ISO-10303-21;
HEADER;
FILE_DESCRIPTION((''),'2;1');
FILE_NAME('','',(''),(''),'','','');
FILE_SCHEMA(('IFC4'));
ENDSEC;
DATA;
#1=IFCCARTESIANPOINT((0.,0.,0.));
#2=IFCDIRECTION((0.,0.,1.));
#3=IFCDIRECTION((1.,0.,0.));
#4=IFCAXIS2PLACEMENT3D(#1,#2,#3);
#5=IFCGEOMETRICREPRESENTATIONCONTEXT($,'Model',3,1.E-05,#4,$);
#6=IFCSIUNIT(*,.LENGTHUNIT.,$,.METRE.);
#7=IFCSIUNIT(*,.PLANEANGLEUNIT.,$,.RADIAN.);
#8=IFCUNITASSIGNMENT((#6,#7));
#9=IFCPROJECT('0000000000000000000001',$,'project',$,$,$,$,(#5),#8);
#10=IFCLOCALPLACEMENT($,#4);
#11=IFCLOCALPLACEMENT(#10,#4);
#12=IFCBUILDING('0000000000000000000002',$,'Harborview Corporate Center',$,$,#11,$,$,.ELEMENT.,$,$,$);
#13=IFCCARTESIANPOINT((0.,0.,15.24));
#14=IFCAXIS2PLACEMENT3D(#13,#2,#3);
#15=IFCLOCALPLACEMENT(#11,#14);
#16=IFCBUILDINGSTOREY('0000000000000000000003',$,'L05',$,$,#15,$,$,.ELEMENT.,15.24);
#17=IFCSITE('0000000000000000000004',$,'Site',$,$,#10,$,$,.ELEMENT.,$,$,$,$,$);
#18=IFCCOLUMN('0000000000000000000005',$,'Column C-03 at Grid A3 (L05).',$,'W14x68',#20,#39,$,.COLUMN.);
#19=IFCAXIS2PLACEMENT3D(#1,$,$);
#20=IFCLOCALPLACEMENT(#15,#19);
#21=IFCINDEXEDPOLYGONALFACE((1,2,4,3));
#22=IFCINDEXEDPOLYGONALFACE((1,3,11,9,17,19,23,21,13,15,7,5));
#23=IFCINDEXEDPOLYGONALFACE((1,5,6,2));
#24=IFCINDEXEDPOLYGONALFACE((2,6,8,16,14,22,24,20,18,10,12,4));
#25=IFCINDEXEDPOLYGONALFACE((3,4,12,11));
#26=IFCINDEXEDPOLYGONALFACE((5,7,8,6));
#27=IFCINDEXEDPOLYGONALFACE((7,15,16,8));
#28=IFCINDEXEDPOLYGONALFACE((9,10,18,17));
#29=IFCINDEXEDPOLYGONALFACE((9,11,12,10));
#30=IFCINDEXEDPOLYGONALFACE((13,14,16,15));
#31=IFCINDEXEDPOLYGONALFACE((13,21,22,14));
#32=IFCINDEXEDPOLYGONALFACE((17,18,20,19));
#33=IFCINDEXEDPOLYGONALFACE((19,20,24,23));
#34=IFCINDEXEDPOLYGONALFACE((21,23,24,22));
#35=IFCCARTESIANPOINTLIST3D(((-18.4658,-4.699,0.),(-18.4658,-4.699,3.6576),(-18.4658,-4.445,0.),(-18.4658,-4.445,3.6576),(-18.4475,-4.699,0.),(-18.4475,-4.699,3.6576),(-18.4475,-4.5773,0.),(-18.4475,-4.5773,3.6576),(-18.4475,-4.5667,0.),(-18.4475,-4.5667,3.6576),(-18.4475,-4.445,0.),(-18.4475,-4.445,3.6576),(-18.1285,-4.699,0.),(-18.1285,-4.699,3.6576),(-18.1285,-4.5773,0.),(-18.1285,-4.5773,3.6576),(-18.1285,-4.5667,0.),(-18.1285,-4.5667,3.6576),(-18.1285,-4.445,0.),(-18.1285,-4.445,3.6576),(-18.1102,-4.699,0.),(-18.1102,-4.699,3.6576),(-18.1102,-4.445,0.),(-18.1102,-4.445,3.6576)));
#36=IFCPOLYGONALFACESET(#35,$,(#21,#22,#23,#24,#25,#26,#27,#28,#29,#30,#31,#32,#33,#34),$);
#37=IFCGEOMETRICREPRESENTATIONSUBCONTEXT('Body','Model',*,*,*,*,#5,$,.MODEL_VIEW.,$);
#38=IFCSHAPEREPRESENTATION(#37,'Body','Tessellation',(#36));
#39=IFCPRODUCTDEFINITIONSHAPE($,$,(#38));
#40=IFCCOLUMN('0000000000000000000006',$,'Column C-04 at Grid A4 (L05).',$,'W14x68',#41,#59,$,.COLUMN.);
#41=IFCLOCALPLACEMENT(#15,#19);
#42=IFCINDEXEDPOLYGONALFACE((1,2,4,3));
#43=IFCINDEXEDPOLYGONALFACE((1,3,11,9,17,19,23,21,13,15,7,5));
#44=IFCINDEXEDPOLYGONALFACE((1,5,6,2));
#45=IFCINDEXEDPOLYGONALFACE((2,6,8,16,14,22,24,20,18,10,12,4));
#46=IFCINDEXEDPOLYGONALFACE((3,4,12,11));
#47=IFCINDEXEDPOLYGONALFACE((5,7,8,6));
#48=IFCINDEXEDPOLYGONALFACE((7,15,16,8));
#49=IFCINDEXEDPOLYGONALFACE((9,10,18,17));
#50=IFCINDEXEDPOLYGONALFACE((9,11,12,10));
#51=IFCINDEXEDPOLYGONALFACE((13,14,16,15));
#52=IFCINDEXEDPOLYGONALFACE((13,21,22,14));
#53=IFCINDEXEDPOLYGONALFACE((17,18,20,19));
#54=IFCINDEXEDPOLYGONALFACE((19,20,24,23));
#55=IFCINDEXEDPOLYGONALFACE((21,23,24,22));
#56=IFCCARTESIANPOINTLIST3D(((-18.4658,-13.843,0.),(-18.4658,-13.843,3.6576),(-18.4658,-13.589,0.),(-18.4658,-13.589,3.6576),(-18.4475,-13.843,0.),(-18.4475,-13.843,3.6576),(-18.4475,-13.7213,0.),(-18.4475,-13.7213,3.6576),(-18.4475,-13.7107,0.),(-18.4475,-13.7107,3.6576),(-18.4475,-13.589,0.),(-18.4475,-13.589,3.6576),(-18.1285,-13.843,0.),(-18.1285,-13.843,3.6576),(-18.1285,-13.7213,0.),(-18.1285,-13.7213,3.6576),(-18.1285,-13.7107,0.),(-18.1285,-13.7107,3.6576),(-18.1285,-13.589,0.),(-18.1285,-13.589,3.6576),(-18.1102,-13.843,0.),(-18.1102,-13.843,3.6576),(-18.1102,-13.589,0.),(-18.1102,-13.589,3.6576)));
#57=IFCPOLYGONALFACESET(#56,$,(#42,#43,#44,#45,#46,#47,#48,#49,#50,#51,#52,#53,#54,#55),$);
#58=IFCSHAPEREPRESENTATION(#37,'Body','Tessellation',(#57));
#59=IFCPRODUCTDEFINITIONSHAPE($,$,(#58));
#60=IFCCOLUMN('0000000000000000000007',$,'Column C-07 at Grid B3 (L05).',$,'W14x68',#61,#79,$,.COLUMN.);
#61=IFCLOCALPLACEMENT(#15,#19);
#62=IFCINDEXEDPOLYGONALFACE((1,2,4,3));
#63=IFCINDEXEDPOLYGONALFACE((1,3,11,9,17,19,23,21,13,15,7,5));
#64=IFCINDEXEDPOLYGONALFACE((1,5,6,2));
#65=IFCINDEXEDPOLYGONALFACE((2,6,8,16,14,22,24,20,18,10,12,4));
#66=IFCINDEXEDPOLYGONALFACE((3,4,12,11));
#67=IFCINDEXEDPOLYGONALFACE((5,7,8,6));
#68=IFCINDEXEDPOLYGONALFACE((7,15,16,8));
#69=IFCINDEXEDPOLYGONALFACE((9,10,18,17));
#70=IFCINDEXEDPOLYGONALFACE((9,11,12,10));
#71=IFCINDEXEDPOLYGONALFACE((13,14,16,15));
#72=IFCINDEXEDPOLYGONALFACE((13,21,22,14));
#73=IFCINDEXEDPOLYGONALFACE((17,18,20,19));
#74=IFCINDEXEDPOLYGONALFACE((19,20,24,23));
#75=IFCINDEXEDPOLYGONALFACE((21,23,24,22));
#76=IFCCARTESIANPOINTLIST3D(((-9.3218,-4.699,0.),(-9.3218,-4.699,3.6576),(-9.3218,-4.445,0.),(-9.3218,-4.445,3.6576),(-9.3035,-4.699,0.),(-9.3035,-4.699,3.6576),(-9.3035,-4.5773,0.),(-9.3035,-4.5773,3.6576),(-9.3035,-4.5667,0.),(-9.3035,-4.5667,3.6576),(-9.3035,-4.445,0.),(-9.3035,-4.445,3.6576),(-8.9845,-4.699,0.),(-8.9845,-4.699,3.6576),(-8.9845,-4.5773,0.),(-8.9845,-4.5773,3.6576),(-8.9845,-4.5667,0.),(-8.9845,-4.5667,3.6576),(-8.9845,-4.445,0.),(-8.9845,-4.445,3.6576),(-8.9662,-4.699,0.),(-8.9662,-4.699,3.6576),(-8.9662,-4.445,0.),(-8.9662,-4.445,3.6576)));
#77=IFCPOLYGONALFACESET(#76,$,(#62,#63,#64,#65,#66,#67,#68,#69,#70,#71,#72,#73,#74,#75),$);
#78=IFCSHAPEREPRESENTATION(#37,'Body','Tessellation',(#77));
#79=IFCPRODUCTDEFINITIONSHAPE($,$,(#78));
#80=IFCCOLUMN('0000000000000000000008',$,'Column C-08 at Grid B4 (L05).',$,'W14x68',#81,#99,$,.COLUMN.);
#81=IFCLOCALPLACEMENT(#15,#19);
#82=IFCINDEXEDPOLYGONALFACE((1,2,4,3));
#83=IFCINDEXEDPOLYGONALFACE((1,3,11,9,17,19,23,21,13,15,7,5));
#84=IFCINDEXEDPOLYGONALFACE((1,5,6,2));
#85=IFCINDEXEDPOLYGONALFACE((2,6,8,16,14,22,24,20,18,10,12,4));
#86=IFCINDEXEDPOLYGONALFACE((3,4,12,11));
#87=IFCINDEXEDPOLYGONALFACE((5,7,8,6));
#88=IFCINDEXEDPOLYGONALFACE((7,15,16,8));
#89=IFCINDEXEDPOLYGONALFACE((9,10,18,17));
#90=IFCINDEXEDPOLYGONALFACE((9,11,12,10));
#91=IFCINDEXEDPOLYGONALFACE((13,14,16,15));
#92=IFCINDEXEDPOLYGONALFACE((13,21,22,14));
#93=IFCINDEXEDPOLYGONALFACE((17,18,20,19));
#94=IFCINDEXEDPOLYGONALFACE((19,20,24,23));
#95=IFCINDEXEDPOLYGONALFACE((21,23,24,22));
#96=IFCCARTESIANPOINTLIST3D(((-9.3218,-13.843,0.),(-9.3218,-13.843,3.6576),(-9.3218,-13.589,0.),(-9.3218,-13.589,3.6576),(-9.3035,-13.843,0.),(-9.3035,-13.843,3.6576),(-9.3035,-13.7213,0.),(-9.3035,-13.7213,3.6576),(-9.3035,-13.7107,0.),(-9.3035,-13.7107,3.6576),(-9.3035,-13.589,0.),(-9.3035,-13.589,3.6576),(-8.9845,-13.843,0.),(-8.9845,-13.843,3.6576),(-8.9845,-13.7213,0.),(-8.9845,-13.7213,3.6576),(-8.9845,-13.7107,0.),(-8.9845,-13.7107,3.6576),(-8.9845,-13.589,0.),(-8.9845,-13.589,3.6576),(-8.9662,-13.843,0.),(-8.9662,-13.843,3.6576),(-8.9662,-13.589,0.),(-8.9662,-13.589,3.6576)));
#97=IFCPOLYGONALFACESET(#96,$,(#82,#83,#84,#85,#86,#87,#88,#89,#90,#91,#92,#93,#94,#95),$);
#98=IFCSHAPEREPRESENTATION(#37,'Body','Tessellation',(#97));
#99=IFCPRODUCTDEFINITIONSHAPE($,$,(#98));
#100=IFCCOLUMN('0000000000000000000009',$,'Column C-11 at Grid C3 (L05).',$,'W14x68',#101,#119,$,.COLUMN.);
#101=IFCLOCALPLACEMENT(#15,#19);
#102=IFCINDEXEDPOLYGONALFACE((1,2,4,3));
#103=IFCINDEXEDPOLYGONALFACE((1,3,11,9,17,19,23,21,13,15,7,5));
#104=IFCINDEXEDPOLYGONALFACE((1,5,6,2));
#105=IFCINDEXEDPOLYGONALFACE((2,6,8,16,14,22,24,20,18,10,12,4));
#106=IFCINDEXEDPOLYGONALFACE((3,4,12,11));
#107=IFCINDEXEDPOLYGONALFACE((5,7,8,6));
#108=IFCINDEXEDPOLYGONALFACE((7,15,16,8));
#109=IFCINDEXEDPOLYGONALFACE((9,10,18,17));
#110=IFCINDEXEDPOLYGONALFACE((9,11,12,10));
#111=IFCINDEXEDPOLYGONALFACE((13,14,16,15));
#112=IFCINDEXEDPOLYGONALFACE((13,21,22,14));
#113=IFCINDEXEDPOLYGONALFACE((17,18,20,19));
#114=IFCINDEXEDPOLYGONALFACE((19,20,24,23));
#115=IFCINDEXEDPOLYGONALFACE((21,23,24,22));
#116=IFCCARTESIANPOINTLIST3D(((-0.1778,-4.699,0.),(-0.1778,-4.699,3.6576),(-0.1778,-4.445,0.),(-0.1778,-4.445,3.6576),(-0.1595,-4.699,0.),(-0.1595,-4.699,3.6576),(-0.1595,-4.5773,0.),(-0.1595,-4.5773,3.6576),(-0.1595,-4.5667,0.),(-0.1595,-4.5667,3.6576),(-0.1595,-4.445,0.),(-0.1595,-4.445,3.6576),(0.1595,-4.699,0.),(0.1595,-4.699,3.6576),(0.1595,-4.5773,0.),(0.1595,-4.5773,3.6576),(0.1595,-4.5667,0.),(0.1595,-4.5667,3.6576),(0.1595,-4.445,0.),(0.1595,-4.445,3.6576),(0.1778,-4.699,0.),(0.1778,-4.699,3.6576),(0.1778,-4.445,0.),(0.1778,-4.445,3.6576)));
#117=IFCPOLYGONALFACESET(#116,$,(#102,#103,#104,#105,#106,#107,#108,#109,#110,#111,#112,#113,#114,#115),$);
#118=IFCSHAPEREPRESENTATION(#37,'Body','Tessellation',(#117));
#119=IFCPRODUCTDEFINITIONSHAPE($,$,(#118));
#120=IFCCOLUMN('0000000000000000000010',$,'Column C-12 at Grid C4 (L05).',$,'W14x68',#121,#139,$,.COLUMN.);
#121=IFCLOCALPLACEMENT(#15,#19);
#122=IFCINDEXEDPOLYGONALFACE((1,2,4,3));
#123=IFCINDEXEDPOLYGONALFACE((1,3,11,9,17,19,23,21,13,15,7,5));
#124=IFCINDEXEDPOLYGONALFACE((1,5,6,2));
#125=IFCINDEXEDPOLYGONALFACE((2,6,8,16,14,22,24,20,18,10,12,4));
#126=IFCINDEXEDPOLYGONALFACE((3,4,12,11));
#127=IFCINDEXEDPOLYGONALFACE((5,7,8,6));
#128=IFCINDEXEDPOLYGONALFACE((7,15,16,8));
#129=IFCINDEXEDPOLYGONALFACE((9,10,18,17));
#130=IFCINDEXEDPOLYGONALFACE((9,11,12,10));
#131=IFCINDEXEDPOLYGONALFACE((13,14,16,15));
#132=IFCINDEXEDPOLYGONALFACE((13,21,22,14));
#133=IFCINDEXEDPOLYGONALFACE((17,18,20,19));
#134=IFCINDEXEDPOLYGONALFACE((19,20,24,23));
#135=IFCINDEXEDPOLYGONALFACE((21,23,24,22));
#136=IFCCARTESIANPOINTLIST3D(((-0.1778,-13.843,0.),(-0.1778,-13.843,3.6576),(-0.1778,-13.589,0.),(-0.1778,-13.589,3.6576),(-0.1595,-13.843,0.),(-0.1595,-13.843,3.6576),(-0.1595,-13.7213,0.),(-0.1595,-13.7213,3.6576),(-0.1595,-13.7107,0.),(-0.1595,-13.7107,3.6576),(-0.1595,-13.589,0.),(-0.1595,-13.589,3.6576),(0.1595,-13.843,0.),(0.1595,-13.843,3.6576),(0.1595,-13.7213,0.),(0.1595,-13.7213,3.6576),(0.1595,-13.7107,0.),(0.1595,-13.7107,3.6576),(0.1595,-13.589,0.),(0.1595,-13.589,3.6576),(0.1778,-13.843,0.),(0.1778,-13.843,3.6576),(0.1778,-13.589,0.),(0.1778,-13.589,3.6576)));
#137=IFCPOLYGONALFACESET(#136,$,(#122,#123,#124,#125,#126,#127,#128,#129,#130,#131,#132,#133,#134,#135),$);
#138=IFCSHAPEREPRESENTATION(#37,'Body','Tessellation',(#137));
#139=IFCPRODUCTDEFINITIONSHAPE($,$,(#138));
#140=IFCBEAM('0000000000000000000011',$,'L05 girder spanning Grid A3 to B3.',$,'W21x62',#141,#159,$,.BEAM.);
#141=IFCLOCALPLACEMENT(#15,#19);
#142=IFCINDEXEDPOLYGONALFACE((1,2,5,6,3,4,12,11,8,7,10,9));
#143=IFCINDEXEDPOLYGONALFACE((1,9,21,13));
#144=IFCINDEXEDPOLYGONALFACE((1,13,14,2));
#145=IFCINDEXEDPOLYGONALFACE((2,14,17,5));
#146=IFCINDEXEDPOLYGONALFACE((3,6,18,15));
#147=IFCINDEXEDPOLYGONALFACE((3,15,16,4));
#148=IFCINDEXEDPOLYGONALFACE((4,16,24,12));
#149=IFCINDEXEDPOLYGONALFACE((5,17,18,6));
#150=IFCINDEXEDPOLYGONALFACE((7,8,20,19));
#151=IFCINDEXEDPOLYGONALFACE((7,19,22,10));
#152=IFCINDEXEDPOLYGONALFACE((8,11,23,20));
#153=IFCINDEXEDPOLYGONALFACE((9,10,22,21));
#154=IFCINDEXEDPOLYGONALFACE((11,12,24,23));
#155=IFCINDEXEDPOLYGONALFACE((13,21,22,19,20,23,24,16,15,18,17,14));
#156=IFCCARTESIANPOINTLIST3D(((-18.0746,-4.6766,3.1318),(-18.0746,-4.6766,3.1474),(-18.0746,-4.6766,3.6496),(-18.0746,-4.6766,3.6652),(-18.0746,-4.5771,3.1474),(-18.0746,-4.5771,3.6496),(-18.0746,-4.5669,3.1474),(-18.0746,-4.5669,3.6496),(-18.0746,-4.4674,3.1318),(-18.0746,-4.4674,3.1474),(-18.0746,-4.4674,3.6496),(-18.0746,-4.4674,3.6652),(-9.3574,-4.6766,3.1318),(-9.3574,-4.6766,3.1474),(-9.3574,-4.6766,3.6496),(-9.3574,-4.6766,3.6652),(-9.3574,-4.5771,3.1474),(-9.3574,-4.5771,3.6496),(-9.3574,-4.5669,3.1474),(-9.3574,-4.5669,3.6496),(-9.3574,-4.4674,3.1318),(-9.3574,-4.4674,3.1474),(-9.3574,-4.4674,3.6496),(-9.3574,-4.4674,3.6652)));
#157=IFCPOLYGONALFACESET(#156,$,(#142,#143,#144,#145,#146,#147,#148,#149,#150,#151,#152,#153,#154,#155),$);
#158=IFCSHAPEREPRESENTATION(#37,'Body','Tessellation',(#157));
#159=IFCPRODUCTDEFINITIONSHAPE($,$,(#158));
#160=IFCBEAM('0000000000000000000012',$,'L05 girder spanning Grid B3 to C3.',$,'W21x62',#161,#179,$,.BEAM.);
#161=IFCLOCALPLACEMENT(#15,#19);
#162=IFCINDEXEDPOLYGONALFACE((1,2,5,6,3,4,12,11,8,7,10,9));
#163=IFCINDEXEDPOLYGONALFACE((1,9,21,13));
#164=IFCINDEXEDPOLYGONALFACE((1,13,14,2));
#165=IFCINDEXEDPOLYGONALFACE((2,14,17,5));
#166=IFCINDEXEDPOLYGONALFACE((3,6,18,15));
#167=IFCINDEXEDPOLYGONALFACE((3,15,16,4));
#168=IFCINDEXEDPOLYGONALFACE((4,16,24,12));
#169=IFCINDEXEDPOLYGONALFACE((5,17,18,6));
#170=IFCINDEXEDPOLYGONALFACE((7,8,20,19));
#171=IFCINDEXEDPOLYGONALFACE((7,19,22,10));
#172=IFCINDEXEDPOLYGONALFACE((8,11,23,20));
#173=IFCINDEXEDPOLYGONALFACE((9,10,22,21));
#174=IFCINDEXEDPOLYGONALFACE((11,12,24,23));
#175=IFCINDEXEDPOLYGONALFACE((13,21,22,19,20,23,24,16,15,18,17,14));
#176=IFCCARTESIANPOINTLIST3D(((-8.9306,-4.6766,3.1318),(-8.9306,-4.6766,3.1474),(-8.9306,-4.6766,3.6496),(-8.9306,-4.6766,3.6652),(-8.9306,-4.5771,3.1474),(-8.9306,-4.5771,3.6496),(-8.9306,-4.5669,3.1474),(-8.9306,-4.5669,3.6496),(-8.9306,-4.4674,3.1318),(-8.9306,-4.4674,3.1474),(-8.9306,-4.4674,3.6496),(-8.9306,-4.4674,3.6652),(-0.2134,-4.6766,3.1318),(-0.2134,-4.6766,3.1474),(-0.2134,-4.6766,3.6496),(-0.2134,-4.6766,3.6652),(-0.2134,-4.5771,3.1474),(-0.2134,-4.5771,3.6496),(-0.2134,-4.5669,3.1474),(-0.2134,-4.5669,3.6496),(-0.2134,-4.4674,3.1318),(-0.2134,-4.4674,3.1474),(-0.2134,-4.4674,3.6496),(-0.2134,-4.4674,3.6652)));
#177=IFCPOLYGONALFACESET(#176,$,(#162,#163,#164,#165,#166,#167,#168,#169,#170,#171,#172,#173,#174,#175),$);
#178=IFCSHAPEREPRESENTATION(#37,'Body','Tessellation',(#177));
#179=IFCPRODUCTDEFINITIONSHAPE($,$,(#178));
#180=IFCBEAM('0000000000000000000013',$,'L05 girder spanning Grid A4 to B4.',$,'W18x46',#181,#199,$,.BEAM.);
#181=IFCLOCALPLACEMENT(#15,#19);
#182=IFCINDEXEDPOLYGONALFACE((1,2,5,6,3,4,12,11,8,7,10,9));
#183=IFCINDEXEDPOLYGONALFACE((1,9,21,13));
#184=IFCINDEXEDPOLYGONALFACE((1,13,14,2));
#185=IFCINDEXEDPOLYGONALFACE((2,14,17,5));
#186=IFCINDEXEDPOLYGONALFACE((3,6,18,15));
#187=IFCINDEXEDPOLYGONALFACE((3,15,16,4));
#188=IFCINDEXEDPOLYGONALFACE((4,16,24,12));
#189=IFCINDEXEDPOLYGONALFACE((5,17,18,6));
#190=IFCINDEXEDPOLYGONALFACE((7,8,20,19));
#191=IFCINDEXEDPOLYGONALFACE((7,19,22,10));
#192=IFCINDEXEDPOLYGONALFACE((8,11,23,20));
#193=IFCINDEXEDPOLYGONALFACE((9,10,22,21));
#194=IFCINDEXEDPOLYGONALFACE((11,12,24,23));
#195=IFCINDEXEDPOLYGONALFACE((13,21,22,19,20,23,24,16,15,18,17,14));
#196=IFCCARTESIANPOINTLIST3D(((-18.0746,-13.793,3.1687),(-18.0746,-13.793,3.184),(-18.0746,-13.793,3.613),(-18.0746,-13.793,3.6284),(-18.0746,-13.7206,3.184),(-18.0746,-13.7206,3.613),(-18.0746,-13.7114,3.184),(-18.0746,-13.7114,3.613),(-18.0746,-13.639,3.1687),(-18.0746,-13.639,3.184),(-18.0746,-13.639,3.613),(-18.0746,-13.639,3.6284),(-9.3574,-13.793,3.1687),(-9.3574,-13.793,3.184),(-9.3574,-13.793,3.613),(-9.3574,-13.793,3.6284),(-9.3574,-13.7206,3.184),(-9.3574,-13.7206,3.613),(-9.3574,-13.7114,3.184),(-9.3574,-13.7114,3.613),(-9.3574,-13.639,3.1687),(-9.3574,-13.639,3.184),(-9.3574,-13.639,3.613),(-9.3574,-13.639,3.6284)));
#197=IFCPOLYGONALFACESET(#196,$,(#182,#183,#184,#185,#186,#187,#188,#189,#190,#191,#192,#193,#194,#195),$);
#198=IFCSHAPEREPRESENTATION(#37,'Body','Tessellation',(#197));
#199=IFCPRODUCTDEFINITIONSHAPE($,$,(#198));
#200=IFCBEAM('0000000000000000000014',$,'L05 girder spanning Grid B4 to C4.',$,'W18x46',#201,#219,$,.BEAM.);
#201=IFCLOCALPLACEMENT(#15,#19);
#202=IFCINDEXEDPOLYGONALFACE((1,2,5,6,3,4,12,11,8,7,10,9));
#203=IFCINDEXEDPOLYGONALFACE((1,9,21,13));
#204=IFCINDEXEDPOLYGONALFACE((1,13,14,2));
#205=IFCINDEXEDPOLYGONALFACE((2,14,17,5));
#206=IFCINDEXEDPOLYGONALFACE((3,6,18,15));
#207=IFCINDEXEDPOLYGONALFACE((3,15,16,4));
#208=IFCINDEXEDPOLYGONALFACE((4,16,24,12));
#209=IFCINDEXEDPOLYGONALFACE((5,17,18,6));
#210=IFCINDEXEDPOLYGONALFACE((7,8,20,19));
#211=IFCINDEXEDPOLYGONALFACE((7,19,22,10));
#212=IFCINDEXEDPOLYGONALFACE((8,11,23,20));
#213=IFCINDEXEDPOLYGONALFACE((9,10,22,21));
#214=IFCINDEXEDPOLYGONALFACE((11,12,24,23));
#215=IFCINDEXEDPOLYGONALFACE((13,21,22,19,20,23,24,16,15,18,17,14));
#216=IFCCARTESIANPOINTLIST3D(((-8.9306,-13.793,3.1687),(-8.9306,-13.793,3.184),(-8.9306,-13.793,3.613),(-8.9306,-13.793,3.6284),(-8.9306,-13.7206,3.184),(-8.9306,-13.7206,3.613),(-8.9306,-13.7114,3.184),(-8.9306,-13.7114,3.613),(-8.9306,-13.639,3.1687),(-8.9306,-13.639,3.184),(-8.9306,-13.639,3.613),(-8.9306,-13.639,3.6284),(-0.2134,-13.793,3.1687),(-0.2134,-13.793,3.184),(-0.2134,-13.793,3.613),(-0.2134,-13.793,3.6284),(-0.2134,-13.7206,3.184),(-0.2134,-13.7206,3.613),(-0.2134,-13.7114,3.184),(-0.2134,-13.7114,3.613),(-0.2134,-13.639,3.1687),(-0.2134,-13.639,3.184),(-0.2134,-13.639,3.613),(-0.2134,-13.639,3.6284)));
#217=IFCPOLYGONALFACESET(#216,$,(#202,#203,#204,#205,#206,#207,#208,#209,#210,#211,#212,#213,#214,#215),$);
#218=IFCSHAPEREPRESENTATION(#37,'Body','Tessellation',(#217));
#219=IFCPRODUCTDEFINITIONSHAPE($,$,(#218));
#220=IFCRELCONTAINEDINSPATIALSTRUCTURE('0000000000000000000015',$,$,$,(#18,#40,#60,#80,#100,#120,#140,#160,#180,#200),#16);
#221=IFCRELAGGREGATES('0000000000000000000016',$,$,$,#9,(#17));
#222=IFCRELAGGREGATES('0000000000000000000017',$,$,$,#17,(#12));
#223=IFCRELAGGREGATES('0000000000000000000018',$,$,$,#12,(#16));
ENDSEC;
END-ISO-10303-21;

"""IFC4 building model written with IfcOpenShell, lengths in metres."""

from ifc_helpers import new_model, si_unit, frame, origin_with_axes, place, context, subcontext, project, spatial, i_section, extrude, element, save


model = new_model("IFC4")

# Units and contexts
model_context = context("Model", 3, precision=1e-05, world=origin_with_axes())
body_context = subcontext(model_context, "Body", "Model", "MODEL_VIEW")
ifc_project = project(units=[si_unit("LENGTHUNIT", "METRE"), si_unit("PLANEANGLEUNIT", "RADIAN")], contexts=[model_context])

# Site, building, storey
site_placement = place(None, origin_with_axes())
site = spatial("IfcSite", under=ifc_project, at=site_placement, Name="Site", CompositionType="ELEMENT")
building_placement = place(site_placement, origin_with_axes())
building = spatial("IfcBuilding", under=site, at=building_placement, Name="Harborview Corporate Center", CompositionType="ELEMENT")
storey_placement = place(building_placement, frame((0.0, 0.0, 15.24), z_axis=(0.0, 0.0, 1.0), x_axis=(1.0, 0.0, 0.0)))
storey = spatial("IfcBuildingStorey", under=building, at=storey_placement, Name="L05", CompositionType="ELEMENT", Elevation=15.24)

# Columns
for number, where, z_axis, x_axis, name in (
    (1, (-18.288, -4.572, 0.0), (0.0, 0.0, 1.0), (0.0, 1.0, 0.0), "Column C-03 at Grid A3 (L05)."),
    (2, (-18.288, -13.716, 0.0), (0.0, 0.0, 1.0), (0.0, 1.0, 0.0), "Column C-04 at Grid A4 (L05)."),
    (3, (-9.144, -4.572, 0.0), (0.0, 0.0, 1.0), (0.0, 1.0, 0.0), "Column C-07 at Grid B3 (L05)."),
    (4, (-9.144, -13.716, 0.0), (0.0, 0.0, 1.0), (0.0, 1.0, 0.0), "Column C-08 at Grid B4 (L05)."),
    (5, (0.0, -4.572, 0.0), (0.0, 0.0, 1.0), (0.0, 1.0, 0.0), "Column C-11 at Grid C3 (L05)."),
    (6, (0.0, -13.716, 0.0), (0.0, 0.0, 1.0), (0.0, 1.0, 0.0), "Column C-12 at Grid C4 (L05)."),
):
    element("IfcColumn", number, at=place(storey_placement, frame(where, z_axis=z_axis, x_axis=x_axis)), inside=storey, Name=name, ObjectType="W14x68", PredefinedType="COLUMN", context=body_context, shape_type="SweptSolid", body=[
        extrude(i_section(OverallWidth=0.254, OverallDepth=0.3556, WebThickness=0.0105, FlangeThickness=0.0183), origin_with_axes(), (0.0, 0.0, 1.0), 3.6576),
    ])

# Beams
beam_1_placement = place(storey_placement, frame((-18.0746, -4.572, 3.3985), z_axis=(1.0, 0.0, 0.0), x_axis=(0.0, 1.0, 0.0)))
element("IfcBeam", 7, at=beam_1_placement, inside=storey, Name="L05 girder spanning Grid A3 to B3.", ObjectType="W21x62", PredefinedType="BEAM", context=body_context, shape_type="SweptSolid", body=[
    extrude(i_section(OverallWidth=0.2093, OverallDepth=0.5334, WebThickness=0.0102, FlangeThickness=0.0156), origin_with_axes(), (0.0, 0.0, 1.0), 8.7173),
])
beam_2_placement = place(storey_placement, frame((-8.9306, -4.572, 3.3985), z_axis=(1.0, 0.0, 0.0), x_axis=(0.0, 1.0, 0.0)))
element("IfcBeam", 8, at=beam_2_placement, inside=storey, Name="L05 girder spanning Grid B3 to C3.", ObjectType="W21x62", PredefinedType="BEAM", context=body_context, shape_type="SweptSolid", body=[
    extrude(i_section(OverallWidth=0.2093, OverallDepth=0.5334, WebThickness=0.0102, FlangeThickness=0.0156), origin_with_axes(), (0.0, 0.0, 1.0), 8.7173),
])
beam_3_placement = place(storey_placement, frame((-18.0746, -13.716, 3.3985), z_axis=(1.0, 0.0, 0.0), x_axis=(0.0, 1.0, 0.0)))
element("IfcBeam", 9, at=beam_3_placement, inside=storey, Name="L05 girder spanning Grid A4 to B4.", ObjectType="W18x46", PredefinedType="BEAM", context=body_context, shape_type="SweptSolid", body=[
    extrude(i_section(OverallWidth=0.1539, OverallDepth=0.4597, WebThickness=0.0091, FlangeThickness=0.0154), origin_with_axes(), (0.0, 0.0, 1.0), 8.7173),
])
beam_4_placement = place(storey_placement, frame((-8.9306, -13.716, 3.3985), z_axis=(1.0, 0.0, 0.0), x_axis=(0.0, 1.0, 0.0)))
element("IfcBeam", 10, at=beam_4_placement, inside=storey, Name="L05 girder spanning Grid B4 to C4.", ObjectType="W18x46", PredefinedType="BEAM", context=body_context, shape_type="SweptSolid", body=[
    extrude(i_section(OverallWidth=0.1539, OverallDepth=0.4597, WebThickness=0.0091, FlangeThickness=0.0154), origin_with_axes(), (0.0, 0.0, 1.0), 8.7173),
])

save(model, "model.ifc")
